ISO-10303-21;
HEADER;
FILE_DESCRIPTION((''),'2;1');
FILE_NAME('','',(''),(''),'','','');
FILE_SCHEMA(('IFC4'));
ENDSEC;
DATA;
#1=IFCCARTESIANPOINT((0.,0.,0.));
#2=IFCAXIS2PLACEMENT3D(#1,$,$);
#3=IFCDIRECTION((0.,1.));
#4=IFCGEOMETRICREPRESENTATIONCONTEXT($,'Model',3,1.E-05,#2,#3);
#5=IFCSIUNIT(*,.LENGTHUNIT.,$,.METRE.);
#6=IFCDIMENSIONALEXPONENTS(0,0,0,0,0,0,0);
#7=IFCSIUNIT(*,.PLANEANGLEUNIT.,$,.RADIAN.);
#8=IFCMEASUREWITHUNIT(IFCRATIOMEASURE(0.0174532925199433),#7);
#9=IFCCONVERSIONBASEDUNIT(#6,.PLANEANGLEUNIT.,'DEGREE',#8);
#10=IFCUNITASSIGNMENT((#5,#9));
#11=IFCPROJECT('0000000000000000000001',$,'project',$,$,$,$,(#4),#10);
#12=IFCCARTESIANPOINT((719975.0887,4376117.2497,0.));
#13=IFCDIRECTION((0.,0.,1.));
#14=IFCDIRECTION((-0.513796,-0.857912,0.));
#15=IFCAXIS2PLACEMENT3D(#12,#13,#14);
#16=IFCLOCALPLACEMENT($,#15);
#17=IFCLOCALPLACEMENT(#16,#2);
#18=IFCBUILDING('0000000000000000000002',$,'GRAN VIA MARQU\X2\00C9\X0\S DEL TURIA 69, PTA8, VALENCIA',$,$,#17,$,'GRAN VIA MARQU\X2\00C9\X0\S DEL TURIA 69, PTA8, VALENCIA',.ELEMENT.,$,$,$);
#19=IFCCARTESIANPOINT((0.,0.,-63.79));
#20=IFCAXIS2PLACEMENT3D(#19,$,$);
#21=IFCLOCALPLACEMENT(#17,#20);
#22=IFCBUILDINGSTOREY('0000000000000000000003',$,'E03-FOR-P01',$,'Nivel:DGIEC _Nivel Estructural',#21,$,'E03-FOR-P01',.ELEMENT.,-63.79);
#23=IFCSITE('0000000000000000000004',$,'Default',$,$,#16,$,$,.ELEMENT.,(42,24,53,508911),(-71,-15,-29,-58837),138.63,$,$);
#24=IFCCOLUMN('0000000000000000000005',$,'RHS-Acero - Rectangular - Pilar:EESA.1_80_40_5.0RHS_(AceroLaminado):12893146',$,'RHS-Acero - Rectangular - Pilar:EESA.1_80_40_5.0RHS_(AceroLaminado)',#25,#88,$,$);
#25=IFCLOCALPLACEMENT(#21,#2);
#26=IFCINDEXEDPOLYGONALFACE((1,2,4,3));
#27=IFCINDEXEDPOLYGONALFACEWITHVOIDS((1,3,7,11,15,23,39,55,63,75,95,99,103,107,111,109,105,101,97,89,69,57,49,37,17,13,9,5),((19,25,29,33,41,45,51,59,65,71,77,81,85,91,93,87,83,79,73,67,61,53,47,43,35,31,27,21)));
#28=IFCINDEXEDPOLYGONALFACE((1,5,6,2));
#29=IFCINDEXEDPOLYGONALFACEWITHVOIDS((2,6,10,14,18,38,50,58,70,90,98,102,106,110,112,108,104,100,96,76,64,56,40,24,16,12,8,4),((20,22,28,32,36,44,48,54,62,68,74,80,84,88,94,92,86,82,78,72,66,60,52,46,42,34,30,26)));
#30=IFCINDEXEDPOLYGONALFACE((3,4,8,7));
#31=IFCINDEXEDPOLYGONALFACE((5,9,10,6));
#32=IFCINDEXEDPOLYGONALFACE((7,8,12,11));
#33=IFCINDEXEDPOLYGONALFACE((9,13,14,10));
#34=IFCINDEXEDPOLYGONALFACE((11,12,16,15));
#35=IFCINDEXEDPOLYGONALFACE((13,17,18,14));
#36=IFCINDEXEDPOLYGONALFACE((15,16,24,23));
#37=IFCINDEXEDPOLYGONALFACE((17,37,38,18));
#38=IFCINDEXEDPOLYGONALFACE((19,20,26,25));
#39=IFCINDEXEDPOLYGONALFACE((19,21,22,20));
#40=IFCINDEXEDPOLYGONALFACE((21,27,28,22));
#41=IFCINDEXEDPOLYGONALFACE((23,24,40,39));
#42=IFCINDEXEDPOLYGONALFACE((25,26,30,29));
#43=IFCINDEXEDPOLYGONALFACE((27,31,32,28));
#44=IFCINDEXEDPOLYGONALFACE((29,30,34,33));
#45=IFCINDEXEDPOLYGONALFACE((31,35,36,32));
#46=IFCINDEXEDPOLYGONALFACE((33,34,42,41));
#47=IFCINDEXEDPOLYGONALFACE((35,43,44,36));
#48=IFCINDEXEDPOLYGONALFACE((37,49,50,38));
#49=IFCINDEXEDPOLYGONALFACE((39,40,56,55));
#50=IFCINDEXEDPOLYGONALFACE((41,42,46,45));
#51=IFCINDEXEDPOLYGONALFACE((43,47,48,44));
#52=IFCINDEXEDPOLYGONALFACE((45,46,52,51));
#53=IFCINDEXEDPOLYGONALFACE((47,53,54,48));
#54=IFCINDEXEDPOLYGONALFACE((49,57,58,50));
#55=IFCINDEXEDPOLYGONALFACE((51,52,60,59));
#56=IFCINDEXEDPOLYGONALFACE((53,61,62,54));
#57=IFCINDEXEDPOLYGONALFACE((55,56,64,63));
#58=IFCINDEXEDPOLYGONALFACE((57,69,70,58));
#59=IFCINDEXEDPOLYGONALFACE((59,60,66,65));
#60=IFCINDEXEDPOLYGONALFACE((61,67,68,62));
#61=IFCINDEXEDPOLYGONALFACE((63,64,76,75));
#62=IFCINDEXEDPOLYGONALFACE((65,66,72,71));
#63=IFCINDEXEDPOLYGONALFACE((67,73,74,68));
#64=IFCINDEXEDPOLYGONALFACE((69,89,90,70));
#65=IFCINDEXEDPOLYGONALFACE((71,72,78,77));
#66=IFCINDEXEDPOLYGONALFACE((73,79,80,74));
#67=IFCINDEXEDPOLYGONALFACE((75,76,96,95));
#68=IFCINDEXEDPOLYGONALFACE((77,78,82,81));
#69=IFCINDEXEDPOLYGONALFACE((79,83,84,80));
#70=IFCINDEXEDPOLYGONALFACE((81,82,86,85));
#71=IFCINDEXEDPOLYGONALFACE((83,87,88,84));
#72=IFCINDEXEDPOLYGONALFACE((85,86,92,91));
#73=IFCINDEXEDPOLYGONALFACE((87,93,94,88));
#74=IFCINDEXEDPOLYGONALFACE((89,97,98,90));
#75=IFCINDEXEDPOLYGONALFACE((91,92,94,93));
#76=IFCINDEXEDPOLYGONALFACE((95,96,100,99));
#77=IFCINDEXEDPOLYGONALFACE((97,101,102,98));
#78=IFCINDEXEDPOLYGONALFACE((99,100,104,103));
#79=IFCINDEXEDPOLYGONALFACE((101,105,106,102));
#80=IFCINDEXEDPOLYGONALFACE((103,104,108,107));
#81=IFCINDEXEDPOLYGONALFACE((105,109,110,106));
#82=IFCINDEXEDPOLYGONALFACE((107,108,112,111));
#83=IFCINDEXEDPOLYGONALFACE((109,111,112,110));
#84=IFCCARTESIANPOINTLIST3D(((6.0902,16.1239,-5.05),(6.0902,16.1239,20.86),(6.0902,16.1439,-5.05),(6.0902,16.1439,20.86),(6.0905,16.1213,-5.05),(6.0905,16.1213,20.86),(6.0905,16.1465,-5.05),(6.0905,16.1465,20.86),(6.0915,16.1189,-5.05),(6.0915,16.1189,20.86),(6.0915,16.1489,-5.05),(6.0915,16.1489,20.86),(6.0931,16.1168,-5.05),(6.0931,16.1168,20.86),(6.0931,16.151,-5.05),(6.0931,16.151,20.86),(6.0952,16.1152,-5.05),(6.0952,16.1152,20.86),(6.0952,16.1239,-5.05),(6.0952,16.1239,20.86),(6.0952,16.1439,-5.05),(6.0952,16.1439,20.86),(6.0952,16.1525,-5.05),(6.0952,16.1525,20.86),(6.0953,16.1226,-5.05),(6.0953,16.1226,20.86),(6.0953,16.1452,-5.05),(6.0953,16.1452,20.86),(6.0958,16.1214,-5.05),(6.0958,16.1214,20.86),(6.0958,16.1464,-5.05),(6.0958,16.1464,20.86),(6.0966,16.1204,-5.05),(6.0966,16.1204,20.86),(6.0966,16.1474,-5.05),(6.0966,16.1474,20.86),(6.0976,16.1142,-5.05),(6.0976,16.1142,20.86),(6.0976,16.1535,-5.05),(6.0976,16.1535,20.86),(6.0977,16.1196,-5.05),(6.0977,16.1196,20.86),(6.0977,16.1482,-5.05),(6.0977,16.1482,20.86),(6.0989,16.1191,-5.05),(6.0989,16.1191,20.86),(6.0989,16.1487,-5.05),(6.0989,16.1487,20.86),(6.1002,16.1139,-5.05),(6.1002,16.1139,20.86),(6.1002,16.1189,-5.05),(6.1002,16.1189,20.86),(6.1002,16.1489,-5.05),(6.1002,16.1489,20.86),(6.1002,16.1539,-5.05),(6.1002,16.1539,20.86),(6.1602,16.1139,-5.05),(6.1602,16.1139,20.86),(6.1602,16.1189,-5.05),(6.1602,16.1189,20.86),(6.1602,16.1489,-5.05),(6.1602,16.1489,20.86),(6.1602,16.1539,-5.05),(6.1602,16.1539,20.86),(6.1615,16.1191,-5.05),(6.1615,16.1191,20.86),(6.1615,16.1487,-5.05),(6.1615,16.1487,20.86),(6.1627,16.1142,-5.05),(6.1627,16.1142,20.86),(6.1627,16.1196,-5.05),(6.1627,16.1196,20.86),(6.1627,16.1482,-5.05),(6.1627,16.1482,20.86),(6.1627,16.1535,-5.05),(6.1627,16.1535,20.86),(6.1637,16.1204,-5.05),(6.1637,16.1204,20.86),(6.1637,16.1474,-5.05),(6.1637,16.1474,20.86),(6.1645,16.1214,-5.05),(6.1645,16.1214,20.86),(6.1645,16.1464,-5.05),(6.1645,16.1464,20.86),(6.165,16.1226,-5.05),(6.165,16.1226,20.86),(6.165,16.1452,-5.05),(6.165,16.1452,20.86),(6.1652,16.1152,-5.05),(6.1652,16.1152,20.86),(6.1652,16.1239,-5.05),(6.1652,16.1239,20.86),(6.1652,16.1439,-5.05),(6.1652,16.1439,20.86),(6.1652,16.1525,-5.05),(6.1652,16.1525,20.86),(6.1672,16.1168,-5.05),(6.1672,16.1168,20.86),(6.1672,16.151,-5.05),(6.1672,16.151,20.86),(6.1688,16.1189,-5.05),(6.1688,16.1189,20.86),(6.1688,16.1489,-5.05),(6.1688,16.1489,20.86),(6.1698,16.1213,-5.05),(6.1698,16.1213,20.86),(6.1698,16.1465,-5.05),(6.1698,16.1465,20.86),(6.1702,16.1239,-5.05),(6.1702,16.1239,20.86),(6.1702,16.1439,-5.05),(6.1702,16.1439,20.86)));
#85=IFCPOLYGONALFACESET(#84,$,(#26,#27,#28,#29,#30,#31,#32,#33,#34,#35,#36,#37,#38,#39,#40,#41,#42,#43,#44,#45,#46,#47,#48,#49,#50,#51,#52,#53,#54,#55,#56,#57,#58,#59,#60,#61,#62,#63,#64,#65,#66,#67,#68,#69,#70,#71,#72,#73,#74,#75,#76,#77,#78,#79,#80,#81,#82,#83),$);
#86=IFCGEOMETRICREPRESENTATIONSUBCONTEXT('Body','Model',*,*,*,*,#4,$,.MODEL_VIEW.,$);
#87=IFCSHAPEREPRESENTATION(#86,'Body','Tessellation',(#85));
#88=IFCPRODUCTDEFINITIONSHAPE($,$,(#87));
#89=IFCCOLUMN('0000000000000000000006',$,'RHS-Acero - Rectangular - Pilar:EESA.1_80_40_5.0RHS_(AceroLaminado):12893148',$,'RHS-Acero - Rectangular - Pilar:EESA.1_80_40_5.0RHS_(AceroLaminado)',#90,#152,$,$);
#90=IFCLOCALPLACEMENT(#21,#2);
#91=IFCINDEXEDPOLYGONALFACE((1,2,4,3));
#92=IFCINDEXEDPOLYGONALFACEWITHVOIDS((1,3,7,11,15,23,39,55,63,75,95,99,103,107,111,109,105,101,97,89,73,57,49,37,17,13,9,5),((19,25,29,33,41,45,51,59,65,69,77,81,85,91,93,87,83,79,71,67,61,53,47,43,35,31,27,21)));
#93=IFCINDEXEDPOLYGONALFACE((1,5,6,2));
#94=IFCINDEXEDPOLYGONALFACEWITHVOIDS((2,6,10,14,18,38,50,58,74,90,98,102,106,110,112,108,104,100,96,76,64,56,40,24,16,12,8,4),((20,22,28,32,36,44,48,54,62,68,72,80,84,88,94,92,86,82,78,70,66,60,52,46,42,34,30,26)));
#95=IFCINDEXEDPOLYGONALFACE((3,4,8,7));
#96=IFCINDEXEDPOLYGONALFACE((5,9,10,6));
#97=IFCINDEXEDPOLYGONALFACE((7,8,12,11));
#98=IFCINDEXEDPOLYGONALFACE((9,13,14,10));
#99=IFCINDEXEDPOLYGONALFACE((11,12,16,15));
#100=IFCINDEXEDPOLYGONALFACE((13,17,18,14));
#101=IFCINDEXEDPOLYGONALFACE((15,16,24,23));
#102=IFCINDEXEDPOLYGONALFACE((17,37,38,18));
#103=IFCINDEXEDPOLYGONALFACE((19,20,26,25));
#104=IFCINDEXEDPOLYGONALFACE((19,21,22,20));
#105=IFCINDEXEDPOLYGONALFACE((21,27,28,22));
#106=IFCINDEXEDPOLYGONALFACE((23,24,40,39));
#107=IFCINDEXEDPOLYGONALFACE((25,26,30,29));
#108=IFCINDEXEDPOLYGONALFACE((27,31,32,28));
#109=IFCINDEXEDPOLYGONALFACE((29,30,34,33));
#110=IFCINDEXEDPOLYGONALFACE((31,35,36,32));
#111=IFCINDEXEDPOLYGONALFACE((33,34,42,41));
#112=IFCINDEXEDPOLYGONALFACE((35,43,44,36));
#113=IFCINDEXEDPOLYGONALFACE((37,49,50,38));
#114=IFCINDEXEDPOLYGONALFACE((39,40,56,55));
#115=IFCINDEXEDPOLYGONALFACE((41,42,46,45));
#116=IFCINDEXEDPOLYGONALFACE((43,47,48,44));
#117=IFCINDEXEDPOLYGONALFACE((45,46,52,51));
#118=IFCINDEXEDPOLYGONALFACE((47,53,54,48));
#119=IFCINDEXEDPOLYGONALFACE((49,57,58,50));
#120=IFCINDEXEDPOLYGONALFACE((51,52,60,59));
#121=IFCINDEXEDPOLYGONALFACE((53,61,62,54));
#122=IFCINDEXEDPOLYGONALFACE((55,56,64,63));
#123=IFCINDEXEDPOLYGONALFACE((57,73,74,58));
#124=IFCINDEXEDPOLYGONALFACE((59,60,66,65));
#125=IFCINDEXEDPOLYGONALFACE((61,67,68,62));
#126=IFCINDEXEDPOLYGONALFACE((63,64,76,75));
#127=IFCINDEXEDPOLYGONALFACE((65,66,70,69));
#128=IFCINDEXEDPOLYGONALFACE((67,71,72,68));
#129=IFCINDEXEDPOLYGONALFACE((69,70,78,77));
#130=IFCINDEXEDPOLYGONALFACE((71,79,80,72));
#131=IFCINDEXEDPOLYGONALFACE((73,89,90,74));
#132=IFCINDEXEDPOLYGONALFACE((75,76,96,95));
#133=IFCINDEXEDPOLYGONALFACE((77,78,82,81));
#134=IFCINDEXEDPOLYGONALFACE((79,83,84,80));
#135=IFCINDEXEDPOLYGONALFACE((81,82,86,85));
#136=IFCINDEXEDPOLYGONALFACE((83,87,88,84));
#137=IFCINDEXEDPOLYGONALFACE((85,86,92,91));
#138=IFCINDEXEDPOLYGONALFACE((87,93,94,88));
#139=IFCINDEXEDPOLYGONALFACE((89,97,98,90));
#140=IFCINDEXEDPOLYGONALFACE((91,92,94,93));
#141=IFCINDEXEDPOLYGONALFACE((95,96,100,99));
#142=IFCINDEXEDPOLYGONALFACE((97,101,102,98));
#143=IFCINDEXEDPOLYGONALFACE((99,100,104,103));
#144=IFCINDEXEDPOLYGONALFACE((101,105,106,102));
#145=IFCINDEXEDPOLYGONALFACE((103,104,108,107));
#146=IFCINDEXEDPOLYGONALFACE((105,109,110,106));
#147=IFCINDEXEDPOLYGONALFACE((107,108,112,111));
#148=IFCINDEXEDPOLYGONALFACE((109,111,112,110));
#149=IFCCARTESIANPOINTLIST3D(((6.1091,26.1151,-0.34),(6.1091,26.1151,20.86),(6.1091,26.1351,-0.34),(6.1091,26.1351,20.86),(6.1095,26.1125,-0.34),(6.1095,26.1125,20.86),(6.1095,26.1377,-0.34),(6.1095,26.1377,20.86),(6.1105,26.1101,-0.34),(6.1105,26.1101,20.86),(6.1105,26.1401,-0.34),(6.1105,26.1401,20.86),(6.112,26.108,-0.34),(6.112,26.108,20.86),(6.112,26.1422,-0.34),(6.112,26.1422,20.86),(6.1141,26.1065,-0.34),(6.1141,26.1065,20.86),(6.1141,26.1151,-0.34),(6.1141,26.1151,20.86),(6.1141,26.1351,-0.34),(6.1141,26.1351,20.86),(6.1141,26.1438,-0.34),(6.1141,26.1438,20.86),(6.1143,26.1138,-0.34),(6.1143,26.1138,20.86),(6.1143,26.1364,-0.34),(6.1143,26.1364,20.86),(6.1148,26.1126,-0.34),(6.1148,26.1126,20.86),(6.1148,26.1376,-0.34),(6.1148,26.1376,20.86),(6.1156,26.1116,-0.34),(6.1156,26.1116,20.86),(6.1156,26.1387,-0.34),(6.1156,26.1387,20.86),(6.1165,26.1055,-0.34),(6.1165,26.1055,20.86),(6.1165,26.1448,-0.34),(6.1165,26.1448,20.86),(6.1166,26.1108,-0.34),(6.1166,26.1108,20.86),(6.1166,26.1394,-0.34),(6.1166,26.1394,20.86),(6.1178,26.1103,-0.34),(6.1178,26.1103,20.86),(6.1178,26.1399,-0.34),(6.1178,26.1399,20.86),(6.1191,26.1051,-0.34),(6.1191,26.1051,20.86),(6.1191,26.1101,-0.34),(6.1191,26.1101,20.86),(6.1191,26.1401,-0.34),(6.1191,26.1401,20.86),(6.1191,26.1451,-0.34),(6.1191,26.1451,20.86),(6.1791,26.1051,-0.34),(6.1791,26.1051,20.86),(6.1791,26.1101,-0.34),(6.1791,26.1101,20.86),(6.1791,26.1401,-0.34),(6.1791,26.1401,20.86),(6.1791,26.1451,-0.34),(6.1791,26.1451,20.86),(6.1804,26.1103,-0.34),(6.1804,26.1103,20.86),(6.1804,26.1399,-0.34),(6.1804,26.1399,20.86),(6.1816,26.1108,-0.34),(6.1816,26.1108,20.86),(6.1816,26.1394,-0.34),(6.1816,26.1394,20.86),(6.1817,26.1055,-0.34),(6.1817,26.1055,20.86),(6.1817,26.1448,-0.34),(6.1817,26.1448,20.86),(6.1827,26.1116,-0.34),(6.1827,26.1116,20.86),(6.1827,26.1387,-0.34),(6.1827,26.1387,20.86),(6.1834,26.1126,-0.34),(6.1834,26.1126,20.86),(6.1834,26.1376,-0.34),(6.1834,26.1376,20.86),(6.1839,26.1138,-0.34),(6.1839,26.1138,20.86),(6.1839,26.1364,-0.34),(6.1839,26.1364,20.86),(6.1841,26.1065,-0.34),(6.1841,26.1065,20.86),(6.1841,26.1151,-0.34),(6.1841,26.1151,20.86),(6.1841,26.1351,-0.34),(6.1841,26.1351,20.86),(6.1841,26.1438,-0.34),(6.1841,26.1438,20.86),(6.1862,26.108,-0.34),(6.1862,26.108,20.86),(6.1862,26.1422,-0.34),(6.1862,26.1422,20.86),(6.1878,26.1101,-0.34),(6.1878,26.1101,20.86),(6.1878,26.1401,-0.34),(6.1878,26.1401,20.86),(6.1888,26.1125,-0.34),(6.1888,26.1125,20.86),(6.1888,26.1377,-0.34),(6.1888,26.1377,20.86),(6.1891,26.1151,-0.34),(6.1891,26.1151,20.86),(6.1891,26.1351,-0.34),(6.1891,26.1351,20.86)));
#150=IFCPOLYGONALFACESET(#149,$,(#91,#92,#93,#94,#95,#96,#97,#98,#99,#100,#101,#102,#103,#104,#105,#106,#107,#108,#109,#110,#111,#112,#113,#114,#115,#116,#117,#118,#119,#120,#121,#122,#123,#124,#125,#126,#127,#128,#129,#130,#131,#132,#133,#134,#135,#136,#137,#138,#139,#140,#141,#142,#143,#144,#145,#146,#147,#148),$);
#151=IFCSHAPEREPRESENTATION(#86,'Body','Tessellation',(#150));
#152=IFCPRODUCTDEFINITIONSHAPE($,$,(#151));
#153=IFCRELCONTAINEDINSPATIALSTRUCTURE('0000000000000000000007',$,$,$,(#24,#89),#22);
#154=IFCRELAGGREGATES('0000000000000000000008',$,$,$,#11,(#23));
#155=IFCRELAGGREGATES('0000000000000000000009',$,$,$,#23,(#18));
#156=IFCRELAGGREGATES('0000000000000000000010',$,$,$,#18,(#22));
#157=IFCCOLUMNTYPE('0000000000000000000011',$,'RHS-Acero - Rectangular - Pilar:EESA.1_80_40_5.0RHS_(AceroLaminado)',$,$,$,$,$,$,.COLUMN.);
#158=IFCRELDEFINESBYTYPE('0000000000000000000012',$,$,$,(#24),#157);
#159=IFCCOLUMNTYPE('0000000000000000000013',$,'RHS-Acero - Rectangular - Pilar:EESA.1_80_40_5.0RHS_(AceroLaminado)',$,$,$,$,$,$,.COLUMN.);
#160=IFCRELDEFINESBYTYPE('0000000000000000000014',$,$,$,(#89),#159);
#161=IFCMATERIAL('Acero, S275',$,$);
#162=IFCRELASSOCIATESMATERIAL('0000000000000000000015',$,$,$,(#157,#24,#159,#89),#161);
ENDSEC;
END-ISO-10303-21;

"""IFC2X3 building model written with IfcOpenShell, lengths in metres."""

from ifc_helpers import new_model, entity, si_unit, converted_unit, direction, frame, frame_2d, origin, place, context, subcontext, project, spatial, polyline, circle_curve, parameter, trimmed, segment, composite_curve, outline, extrude, source, transform, mapped, material, type_object, type_shapes, element, save


model = new_model("IFC2X3")

# Units and contexts
model_context = context("Model", 3, precision=1e-05, world=origin(), true_north=direction((0.0, 1.0)))
body_context = subcontext(model_context, "Body", "Model", "MODEL_VIEW")
ifc_project = project(units=[si_unit("LENGTHUNIT", "METRE"), converted_unit("PLANEANGLEUNIT", "DEGREE", entity("IfcRatioMeasure", 0.0174532925199433), si_unit("PLANEANGLEUNIT", "RADIAN"), dimensions=[0, 0, 0, 0, 0, 0, 0])], contexts=[model_context])

# Site, building, storey
site_placement = place(None, frame((719975.0887, 4376117.2497, 0.0), z_axis=(0.0, 0.0, 1.0), x_axis=(-0.513796, -0.857912, 0.0)))
site = spatial("IfcSite", under=ifc_project, at=site_placement, Name="Default", CompositionType="ELEMENT", RefLatitude=(42, 24, 53, 508911), RefLongitude=(-71, -15, -29, -58837), RefElevation=138.63)
building_placement = place(site_placement, origin())
building = spatial("IfcBuilding", under=site, at=building_placement, Name="GRAN VIA MARQUÉS DEL TURIA 69, PTA8, VALENCIA", LongName="GRAN VIA MARQUÉS DEL TURIA 69, PTA8, VALENCIA", CompositionType="ELEMENT")
storey_placement = place(building_placement, frame((0.0, 0.0, -63.79)))
storey = spatial("IfcBuildingStorey", under=building, at=storey_placement, Name="E03-FOR-P01", ObjectType="Nivel:DGIEC _Nivel Estructural", LongName="E03-FOR-P01", CompositionType="ELEMENT", Elevation=-63.79)

# Columns
ifc_material_1 = material(Name="Acero, S275")
column_type_1 = type_object("IfcColumnType", Name="RHS-Acero - Rectangular - Pilar:EESA.1_80_40_5.0RHS_(AceroLaminado)", PredefinedType="COLUMN", material=ifc_material_1)
shared_shape_1 = source(origin(), body_context, "Body", "SweptSolid", [
    extrude(outline(composite_curve([segment(polyline([(-0.01, -0.04), (0.01, -0.04)]), True, "CONTINUOUS"), segment(trimmed(circle_curve(frame_2d((0.01, -0.03), x_axis=(-1.0, 0.0)), 0.01), [parameter(90.0)], [parameter(180.0)], True, "PARAMETER"), True, "CONTINUOUS"), segment(polyline([(0.02, -0.03), (0.02, 0.03)]), True, "CONTINUOUS"), segment(trimmed(circle_curve(frame_2d((0.01, 0.03), x_axis=(-1.0, 0.0)), 0.01), [parameter(180.0)], [parameter(270.0)], True, "PARAMETER"), True, "CONTINUOUS"), segment(polyline([(0.01, 0.04), (-0.01, 0.04)]), True, "CONTINUOUS"), segment(trimmed(circle_curve(frame_2d((-0.01, 0.03), x_axis=(-1.0, 0.0)), 0.01), [parameter(270.0)], [parameter(360.0)], True, "PARAMETER"), True, "CONTINUOUS"), segment(polyline([(-0.02, 0.03), (-0.02, -0.03)]), True, "CONTINUOUS"), segment(trimmed(circle_curve(frame_2d((-0.01, -0.03), x_axis=(-1.0, 0.0)), 0.01), [parameter(360.0)], [parameter(90.0)], True, "PARAMETER"), True, "CONTINUOUS")], self_intersect=False), holes=[composite_curve([segment(trimmed(circle_curve(frame_2d((-0.01, -0.03), x_axis=(-1.0, 0.0)), 0.005), [parameter(0.0)], [parameter(90.0)], True, "PARAMETER"), False, "CONTINUOUS"), segment(polyline([(-0.015, -0.03), (-0.015, 0.03)]), True, "CONTINUOUS"), segment(trimmed(circle_curve(frame_2d((-0.01, 0.03), x_axis=(-1.0, 0.0)), 0.005), [parameter(270.0)], [parameter(0.0)], True, "PARAMETER"), False, "CONTINUOUS"), segment(polyline([(-0.01, 0.035), (0.01, 0.035)]), True, "CONTINUOUS"), segment(trimmed(circle_curve(frame_2d((0.01, 0.03), x_axis=(-1.0, 0.0)), 0.005), [parameter(180.0)], [parameter(270.0)], True, "PARAMETER"), False, "CONTINUOUS"), segment(polyline([(0.015, 0.03), (0.015, -0.03)]), True, "CONTINUOUS"), segment(trimmed(circle_curve(frame_2d((0.01, -0.03), x_axis=(-1.0, 0.0)), 0.005), [parameter(90.0)], [parameter(180.0)], True, "PARAMETER"), False, "CONTINUOUS"), segment(polyline([(0.01, -0.035), (-0.01, -0.035)]), True, "CONTINUOUS")], self_intersect=False)]), frame((0.0, 0.0, -68.84), z_axis=(0.0, 0.0, 1.0), x_axis=(-1.0, 0.0, 0.0)), (0.0, 0.0, 1.0), 25.91),
])
type_shapes(column_type_1, [shared_shape_1])
for number, where, z_axis, x_axis, name in (
    (1, (6.1302, 16.1339, 63.79), (0.0, 0.0, 1.0), (0.0, 1.0, 0.0), "RHS-Acero - Rectangular - Pilar:EESA.1_80_40_5.0RHS_(AceroLaminado):12893146"),
):
    element("IfcColumn", number, at=place(storey_placement, frame(where, z_axis=z_axis, x_axis=x_axis)), inside=storey, type_object=column_type_1, material=ifc_material_1, Name=name, ObjectType="RHS-Acero - Rectangular - Pilar:EESA.1_80_40_5.0RHS_(AceroLaminado)", context=body_context, shape_type="MappedRepresentation", body=[
        mapped(shared_shape_1, transform((0.0, 0.0, 0.0), scale=1.0)),
    ])
column_type_2 = type_object("IfcColumnType", Name="RHS-Acero - Rectangular - Pilar:EESA.1_80_40_5.0RHS_(AceroLaminado)", PredefinedType="COLUMN", material=ifc_material_1)
shared_shape_2 = source(origin(), body_context, "Body", "SweptSolid", [
    extrude(outline(composite_curve([segment(polyline([(-0.01, -0.04), (0.01, -0.04)]), True, "CONTINUOUS"), segment(trimmed(circle_curve(frame_2d((0.01, -0.03), x_axis=(-1.0, 0.0)), 0.01), [parameter(90.0)], [parameter(180.0)], True, "PARAMETER"), True, "CONTINUOUS"), segment(polyline([(0.02, -0.03), (0.02, 0.03)]), True, "CONTINUOUS"), segment(trimmed(circle_curve(frame_2d((0.01, 0.03), x_axis=(-1.0, 0.0)), 0.01), [parameter(180.0)], [parameter(270.0)], True, "PARAMETER"), True, "CONTINUOUS"), segment(polyline([(0.01, 0.04), (-0.01, 0.04)]), True, "CONTINUOUS"), segment(trimmed(circle_curve(frame_2d((-0.01, 0.03), x_axis=(-1.0, 0.0)), 0.01), [parameter(270.0)], [parameter(360.0)], True, "PARAMETER"), True, "CONTINUOUS"), segment(polyline([(-0.02, 0.03), (-0.02, -0.03)]), True, "CONTINUOUS"), segment(trimmed(circle_curve(frame_2d((-0.01, -0.03), x_axis=(-1.0, 0.0)), 0.01), [parameter(360.0)], [parameter(90.0)], True, "PARAMETER"), True, "CONTINUOUS")], self_intersect=False), holes=[composite_curve([segment(trimmed(circle_curve(frame_2d((-0.01, -0.03), x_axis=(-1.0, 0.0)), 0.005), [parameter(0.0)], [parameter(90.0)], True, "PARAMETER"), False, "CONTINUOUS"), segment(polyline([(-0.015, -0.03), (-0.015, 0.03)]), True, "CONTINUOUS"), segment(trimmed(circle_curve(frame_2d((-0.01, 0.03), x_axis=(-1.0, 0.0)), 0.005), [parameter(270.0)], [parameter(0.0)], True, "PARAMETER"), False, "CONTINUOUS"), segment(polyline([(-0.01, 0.035), (0.01, 0.035)]), True, "CONTINUOUS"), segment(trimmed(circle_curve(frame_2d((0.01, 0.03), x_axis=(-1.0, 0.0)), 0.005), [parameter(180.0)], [parameter(270.0)], True, "PARAMETER"), False, "CONTINUOUS"), segment(polyline([(0.015, 0.03), (0.015, -0.03)]), True, "CONTINUOUS"), segment(trimmed(circle_curve(frame_2d((0.01, -0.03), x_axis=(-1.0, 0.0)), 0.005), [parameter(90.0)], [parameter(180.0)], True, "PARAMETER"), False, "CONTINUOUS"), segment(polyline([(0.01, -0.035), (-0.01, -0.035)]), True, "CONTINUOUS")], self_intersect=False)]), frame((0.0, 0.0, -64.13), z_axis=(0.0, 0.0, 1.0), x_axis=(-1.0, 0.0, 0.0)), (0.0, 0.0, 1.0), 21.2),
])
type_shapes(column_type_2, [shared_shape_2])
column_1_placement = place(storey_placement, frame((6.1491, 26.1251, 63.79), z_axis=(0.0, 0.0, 1.0), x_axis=(0.0, 1.0, 0.0)))
element("IfcColumn", 2, at=column_1_placement, inside=storey, type_object=column_type_2, material=ifc_material_1, Name="RHS-Acero - Rectangular - Pilar:EESA.1_80_40_5.0RHS_(AceroLaminado):12893148", ObjectType="RHS-Acero - Rectangular - Pilar:EESA.1_80_40_5.0RHS_(AceroLaminado)", context=body_context, shape_type="MappedRepresentation", body=[
    mapped(shared_shape_2, transform((0.0, 0.0, 0.0), scale=1.0)),
])

save(model, "model.ifc")
